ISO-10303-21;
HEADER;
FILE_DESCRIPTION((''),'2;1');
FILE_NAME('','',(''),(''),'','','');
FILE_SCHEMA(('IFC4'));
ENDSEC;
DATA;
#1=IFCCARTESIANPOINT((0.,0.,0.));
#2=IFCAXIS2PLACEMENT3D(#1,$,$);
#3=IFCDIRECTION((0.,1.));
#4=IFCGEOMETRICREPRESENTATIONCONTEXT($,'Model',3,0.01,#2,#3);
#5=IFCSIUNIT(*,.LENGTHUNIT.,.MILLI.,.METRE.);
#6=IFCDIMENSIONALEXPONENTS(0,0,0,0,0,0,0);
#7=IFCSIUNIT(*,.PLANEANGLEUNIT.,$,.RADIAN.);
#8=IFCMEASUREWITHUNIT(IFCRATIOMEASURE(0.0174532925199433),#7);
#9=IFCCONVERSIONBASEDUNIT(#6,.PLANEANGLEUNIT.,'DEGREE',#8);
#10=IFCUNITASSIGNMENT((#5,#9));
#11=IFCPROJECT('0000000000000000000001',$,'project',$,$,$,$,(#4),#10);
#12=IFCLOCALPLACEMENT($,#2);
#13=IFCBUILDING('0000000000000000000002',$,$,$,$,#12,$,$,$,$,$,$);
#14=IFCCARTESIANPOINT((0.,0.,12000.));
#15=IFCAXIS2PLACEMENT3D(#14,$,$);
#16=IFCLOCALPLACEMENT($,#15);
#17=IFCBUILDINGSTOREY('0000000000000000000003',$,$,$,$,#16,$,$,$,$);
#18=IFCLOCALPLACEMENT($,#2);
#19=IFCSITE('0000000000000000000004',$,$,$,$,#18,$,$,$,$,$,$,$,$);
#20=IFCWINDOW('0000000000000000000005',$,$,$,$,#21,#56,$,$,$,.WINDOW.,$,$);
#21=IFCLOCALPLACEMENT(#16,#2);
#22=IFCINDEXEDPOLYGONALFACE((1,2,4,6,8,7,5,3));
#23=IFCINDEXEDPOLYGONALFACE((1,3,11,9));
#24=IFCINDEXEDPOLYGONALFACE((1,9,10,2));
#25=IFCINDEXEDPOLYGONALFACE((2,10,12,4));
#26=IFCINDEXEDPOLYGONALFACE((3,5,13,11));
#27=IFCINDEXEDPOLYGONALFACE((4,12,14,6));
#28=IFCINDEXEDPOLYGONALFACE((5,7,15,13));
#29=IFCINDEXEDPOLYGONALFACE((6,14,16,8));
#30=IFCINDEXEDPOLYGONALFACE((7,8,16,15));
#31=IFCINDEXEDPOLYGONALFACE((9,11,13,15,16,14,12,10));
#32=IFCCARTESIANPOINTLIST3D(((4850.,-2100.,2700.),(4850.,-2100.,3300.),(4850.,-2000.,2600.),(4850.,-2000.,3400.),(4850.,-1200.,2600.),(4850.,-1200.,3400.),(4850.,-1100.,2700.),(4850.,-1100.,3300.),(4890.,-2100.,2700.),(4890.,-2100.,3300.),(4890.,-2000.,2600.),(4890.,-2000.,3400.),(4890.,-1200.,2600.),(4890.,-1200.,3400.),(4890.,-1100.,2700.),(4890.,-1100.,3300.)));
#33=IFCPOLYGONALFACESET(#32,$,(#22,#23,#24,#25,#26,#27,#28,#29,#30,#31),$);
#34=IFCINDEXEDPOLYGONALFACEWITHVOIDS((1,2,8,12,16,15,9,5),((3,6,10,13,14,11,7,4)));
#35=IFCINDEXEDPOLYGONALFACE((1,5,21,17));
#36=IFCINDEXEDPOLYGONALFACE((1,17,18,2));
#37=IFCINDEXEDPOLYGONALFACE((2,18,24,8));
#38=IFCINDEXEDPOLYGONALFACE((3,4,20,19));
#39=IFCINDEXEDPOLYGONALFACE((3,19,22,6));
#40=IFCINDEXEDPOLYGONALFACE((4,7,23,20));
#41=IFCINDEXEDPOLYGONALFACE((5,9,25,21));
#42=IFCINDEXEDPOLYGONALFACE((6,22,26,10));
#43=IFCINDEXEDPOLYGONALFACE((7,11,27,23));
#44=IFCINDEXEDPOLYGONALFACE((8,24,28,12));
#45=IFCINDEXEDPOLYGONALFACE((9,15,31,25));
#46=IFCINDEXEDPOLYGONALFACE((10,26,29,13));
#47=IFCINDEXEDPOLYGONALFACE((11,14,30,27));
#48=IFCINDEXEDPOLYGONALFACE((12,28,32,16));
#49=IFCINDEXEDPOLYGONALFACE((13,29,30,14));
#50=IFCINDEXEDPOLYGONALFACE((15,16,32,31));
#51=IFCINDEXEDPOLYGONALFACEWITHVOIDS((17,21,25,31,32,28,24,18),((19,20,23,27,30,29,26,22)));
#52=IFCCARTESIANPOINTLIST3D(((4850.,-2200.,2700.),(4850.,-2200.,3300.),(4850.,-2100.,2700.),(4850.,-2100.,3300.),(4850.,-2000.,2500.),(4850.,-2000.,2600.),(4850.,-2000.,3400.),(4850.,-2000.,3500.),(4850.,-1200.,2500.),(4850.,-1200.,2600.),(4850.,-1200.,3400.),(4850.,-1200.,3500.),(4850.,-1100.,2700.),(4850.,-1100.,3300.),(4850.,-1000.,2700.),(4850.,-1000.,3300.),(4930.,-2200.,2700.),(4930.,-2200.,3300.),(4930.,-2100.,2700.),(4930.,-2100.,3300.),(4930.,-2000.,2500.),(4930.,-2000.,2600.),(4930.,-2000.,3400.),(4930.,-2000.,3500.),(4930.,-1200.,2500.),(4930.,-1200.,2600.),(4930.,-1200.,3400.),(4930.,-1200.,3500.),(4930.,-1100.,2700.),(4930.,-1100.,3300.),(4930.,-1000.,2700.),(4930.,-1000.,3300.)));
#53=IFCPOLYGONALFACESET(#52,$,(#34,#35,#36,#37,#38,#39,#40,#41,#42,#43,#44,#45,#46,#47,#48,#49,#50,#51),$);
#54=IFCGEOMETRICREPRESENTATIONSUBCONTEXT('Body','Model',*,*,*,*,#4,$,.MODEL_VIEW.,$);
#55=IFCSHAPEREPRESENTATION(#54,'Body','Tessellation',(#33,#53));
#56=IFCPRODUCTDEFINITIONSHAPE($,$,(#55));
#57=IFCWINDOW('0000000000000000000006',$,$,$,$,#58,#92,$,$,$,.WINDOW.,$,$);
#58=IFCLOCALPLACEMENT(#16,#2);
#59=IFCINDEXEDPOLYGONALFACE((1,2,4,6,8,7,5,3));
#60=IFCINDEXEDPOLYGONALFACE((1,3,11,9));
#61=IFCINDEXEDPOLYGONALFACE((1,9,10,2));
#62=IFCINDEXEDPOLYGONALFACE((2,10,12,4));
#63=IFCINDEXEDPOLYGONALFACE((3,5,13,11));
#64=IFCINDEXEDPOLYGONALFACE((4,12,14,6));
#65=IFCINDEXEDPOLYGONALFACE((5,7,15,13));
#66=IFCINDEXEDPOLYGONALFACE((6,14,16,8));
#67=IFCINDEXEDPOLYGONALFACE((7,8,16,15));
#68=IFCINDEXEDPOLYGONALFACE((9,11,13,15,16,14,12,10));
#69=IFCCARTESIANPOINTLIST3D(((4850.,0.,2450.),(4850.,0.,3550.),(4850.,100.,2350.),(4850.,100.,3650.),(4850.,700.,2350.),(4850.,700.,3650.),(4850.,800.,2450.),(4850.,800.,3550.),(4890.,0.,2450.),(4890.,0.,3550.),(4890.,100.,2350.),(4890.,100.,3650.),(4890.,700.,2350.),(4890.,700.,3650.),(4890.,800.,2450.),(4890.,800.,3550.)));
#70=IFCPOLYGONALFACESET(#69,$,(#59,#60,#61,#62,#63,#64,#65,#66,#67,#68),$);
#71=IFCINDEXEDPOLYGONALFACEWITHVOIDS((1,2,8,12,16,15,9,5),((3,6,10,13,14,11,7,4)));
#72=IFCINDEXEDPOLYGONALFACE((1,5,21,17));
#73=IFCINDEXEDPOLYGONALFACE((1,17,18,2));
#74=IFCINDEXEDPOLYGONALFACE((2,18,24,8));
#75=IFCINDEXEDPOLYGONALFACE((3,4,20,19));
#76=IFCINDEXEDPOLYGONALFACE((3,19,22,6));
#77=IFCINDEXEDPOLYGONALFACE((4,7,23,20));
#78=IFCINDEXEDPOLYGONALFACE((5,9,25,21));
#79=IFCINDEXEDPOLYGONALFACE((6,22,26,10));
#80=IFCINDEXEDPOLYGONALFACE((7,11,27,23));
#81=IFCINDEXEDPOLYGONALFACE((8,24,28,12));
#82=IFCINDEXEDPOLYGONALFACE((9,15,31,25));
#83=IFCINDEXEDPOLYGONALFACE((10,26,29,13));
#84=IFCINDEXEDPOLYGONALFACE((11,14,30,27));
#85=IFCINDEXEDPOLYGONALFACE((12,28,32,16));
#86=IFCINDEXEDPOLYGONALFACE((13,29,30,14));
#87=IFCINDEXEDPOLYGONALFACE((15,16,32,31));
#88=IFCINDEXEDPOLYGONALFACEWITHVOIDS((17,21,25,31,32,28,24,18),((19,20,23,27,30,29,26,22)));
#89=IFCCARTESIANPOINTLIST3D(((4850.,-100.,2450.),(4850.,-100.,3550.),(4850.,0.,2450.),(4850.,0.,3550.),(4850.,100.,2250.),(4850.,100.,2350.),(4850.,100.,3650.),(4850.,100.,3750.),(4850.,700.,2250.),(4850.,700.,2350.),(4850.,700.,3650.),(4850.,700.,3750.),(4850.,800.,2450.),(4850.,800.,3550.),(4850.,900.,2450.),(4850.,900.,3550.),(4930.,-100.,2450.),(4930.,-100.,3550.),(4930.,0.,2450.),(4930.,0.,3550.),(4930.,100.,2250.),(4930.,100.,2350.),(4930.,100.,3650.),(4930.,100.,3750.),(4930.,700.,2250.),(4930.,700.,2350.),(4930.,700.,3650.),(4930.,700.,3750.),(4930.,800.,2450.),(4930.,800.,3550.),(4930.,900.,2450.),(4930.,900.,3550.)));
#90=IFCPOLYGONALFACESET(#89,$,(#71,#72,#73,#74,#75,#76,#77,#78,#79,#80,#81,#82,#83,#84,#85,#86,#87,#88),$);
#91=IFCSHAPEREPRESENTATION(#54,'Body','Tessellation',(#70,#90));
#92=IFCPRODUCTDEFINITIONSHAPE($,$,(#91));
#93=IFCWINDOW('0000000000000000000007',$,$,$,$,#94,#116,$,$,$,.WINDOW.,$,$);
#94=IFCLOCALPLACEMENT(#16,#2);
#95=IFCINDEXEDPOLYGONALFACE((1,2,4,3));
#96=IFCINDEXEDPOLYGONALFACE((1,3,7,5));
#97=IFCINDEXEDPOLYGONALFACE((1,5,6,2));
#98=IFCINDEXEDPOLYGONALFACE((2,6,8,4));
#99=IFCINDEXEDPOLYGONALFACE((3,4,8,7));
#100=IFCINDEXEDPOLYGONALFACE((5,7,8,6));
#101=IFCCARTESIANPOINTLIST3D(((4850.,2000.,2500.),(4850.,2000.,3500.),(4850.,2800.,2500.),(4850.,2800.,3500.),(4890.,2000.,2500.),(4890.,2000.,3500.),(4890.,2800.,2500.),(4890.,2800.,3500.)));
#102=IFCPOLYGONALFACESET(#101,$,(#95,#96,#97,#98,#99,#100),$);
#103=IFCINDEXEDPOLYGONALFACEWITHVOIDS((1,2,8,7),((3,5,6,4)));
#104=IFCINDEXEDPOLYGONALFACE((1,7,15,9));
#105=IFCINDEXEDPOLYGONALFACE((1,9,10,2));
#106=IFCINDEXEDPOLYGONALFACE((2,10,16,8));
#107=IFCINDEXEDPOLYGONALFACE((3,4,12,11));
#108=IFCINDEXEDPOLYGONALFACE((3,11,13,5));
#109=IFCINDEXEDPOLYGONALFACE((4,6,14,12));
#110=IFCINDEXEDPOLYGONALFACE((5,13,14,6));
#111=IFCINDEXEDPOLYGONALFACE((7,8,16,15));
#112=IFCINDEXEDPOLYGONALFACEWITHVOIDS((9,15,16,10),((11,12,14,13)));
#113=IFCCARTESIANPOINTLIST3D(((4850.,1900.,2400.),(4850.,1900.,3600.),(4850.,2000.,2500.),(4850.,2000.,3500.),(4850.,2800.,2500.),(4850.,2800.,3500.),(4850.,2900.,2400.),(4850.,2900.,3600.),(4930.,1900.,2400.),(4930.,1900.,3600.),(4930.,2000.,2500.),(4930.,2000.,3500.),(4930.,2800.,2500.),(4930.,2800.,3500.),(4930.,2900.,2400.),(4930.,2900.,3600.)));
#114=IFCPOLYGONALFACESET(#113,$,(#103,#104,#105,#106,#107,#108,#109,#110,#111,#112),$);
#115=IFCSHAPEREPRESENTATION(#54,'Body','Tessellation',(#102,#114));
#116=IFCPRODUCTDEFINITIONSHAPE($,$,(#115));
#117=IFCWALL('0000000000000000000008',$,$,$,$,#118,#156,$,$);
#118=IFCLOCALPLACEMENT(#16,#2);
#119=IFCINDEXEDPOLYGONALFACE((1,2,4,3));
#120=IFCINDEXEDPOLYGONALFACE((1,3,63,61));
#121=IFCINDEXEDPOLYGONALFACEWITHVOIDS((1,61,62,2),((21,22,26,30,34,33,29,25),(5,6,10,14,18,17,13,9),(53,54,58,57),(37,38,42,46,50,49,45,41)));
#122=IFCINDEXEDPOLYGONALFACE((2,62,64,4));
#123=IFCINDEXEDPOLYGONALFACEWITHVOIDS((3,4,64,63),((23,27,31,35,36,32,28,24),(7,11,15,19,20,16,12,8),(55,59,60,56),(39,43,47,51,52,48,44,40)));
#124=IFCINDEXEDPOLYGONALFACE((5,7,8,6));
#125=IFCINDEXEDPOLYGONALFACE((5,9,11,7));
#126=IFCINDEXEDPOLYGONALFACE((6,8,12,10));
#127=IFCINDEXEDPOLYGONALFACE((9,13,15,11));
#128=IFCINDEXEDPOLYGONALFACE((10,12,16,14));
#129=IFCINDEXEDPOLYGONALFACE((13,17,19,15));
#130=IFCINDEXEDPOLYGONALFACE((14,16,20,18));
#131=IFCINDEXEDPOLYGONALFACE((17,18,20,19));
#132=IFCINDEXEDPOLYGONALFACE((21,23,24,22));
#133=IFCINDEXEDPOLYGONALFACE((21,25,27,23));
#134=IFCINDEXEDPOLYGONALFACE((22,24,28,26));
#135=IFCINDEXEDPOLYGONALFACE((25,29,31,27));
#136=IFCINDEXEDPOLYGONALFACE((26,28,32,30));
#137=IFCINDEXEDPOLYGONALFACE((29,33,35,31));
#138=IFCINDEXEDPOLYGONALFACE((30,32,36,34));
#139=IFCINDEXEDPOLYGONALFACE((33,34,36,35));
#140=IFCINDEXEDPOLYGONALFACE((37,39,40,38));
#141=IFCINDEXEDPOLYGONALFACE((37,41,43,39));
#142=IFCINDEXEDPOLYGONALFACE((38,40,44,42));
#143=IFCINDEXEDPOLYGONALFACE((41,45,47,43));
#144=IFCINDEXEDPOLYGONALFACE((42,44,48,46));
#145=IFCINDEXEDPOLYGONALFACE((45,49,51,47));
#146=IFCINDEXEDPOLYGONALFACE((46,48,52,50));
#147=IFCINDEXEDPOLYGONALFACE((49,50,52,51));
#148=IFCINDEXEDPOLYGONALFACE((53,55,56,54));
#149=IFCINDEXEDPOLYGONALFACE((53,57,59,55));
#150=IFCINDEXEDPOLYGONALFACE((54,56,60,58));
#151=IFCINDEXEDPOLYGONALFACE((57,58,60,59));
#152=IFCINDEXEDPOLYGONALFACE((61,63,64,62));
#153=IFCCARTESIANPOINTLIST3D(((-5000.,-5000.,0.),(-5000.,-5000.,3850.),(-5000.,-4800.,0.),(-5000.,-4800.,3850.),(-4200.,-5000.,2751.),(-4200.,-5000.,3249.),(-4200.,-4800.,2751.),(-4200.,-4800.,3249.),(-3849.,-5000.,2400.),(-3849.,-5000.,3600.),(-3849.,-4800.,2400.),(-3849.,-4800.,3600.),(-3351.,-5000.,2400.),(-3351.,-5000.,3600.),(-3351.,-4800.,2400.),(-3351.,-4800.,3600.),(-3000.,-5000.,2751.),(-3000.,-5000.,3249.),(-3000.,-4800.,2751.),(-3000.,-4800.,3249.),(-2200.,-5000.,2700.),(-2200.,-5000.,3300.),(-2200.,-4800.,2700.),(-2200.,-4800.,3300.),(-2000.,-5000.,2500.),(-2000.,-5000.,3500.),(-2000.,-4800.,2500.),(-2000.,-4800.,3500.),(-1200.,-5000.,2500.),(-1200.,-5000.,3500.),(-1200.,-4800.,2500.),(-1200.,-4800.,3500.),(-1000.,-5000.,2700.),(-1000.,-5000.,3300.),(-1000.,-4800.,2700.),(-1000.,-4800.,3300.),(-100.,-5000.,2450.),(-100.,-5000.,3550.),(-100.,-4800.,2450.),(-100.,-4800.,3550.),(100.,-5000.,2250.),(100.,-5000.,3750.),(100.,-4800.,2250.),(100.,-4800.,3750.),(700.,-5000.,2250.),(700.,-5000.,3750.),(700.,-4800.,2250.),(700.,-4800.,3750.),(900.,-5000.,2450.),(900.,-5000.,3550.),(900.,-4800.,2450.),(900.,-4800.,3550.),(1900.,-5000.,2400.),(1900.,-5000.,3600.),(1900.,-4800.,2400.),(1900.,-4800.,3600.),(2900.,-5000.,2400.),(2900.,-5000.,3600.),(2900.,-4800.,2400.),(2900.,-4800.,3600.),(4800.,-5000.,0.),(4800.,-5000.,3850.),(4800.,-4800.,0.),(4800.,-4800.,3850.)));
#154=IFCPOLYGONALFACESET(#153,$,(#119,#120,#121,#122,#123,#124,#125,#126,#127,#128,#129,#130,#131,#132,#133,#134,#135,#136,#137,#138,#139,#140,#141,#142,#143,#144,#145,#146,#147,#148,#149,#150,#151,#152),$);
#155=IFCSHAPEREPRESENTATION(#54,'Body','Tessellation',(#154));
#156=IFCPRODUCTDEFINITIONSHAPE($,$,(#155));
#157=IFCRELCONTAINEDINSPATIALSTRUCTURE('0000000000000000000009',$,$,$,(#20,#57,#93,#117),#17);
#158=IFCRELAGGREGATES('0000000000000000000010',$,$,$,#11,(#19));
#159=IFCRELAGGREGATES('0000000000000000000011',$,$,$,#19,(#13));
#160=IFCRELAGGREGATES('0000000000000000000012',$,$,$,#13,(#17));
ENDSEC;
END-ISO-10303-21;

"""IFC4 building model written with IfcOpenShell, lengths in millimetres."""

from ifc_helpers import new_model, entity, si_unit, converted_unit, direction, frame, origin, origin_2d, place, context, subcontext, project, spatial, polyline, rectangle, outline, extrude, element, save


model = new_model("IFC4")

# Units and contexts
model_context = context("Model", 3, precision=0.01, world=origin(), true_north=direction((0.0, 1.0)))
body_context = subcontext(model_context, "Body", "Model", "MODEL_VIEW")
ifc_project = project(units=[si_unit("LENGTHUNIT", "METRE", prefix="MILLI"), converted_unit("PLANEANGLEUNIT", "DEGREE", entity("IfcRatioMeasure", 0.0174532925199433), si_unit("PLANEANGLEUNIT", "RADIAN"), dimensions=[0, 0, 0, 0, 0, 0, 0])], contexts=[model_context])

# Site, building, storey
site_placement = place(None, origin())
site = spatial("IfcSite", under=ifc_project, at=site_placement)
building_placement = place(None, origin())
building = spatial("IfcBuilding", under=site, at=building_placement)
storey_placement = place(None, frame((0.0, 0.0, 12000.0)))
storey = spatial("IfcBuildingStorey", under=building, at=storey_placement)

# Shared definitions
cartesian_point_1 = entity("IfcCartesianPoint", [-500.0, -300.0])
shared_polyline_1 = entity("IfcPolyline", [cartesian_point_1, entity("IfcCartesianPoint", [-500.0, 300.0]), entity("IfcCartesianPoint", [-400.0, 400.0]), entity("IfcCartesianPoint", [400.0, 400.0]), entity("IfcCartesianPoint", [500.0, 300.0]), entity("IfcCartesianPoint", [500.0, -300.0]), entity("IfcCartesianPoint", [400.0, -400.0]), entity("IfcCartesianPoint", [-400.0, -400.0]), cartesian_point_1])
cartesian_point_2 = entity("IfcCartesianPoint", [-400.0, -550.0])
shared_polyline_2 = entity("IfcPolyline", [cartesian_point_2, entity("IfcCartesianPoint", [-400.0, 550.0]), entity("IfcCartesianPoint", [-300.0, 650.0]), entity("IfcCartesianPoint", [300.0, 650.0]), entity("IfcCartesianPoint", [400.0, 550.0]), entity("IfcCartesianPoint", [400.0, -550.0]), entity("IfcCartesianPoint", [300.0, -650.0]), entity("IfcCartesianPoint", [-300.0, -650.0]), cartesian_point_2])
cartesian_point_3 = entity("IfcCartesianPoint", [-400.0, -500.0])
shared_polyline_3 = entity("IfcPolyline", [cartesian_point_3, entity("IfcCartesianPoint", [-400.0, 500.0]), entity("IfcCartesianPoint", [-400.0, 500.0]), entity("IfcCartesianPoint", [400.0, 500.0]), entity("IfcCartesianPoint", [400.0, 500.0]), entity("IfcCartesianPoint", [400.0, -500.0]), entity("IfcCartesianPoint", [400.0, -500.0]), entity("IfcCartesianPoint", [-400.0, -500.0]), cartesian_point_3])

# Shared definitions
wall_1_placement = place(storey_placement, frame((4900.0, -100.0, 0.0), z_axis=(0.0, 0.0, 1.0), x_axis=(0.0, 1.0, 0.0)))
window_1_placement = place(wall_1_placement, frame((-1500.0, 50.0, 3000.0)))
window_2_placement = place(wall_1_placement, frame((500.0, 50.0, 3000.0)))
window_3_placement = place(wall_1_placement, frame((2500.0, 50.0, 3000.0)))

# Windows
cartesian_point_4 = entity("IfcCartesianPoint", [-600.0, -300.0])
element("IfcWindow", 1, at=window_1_placement, inside=storey, PredefinedType="WINDOW", context=body_context, shape_type="SweptSolid", body=[
    entity("IfcExtrudedAreaSolid", entity("IfcArbitraryClosedProfileDef", "AREA", None, shared_polyline_1), entity("IfcAxis2Placement3D", entity("IfcCartesianPoint", [0.0, 0.0, 0.0]), entity("IfcDirection", [0.0, -1.0, 0.0]), entity("IfcDirection", [1.0, 0.0, 0.0])), entity("IfcDirection", [0.0, 0.0, 1.0]), 40.0),
    entity("IfcExtrudedAreaSolid", entity("IfcArbitraryProfileDefWithVoids", "AREA", None, entity("IfcPolyline", [cartesian_point_4, entity("IfcCartesianPoint", [-600.0, 300.0]), entity("IfcCartesianPoint", [-400.0, 500.0]), entity("IfcCartesianPoint", [400.0, 500.0]), entity("IfcCartesianPoint", [600.0, 300.0]), entity("IfcCartesianPoint", [600.0, -300.0]), entity("IfcCartesianPoint", [400.0, -500.0]), entity("IfcCartesianPoint", [-400.0, -500.0]), cartesian_point_4]), [shared_polyline_1]), entity("IfcAxis2Placement3D", entity("IfcCartesianPoint", [0.0, 0.0, 0.0]), entity("IfcDirection", [0.0, -1.0, 0.0]), entity("IfcDirection", [1.0, 0.0, 0.0])), entity("IfcDirection", [0.0, 0.0, 1.0]), 80.0),
])
cartesian_point_5 = entity("IfcCartesianPoint", [-500.0, -550.0])
element("IfcWindow", 2, at=window_2_placement, inside=storey, PredefinedType="WINDOW", context=body_context, shape_type="SweptSolid", body=[
    entity("IfcExtrudedAreaSolid", entity("IfcArbitraryClosedProfileDef", "AREA", None, shared_polyline_2), entity("IfcAxis2Placement3D", entity("IfcCartesianPoint", [0.0, 0.0, 0.0]), entity("IfcDirection", [0.0, -1.0, 0.0]), entity("IfcDirection", [1.0, 0.0, 0.0])), entity("IfcDirection", [0.0, 0.0, 1.0]), 40.0),
    entity("IfcExtrudedAreaSolid", entity("IfcArbitraryProfileDefWithVoids", "AREA", None, entity("IfcPolyline", [cartesian_point_5, entity("IfcCartesianPoint", [-500.0, 550.0]), entity("IfcCartesianPoint", [-300.0, 750.0]), entity("IfcCartesianPoint", [300.0, 750.0]), entity("IfcCartesianPoint", [500.0, 550.0]), entity("IfcCartesianPoint", [500.0, -550.0]), entity("IfcCartesianPoint", [300.0, -750.0]), entity("IfcCartesianPoint", [-300.0, -750.0]), cartesian_point_5]), [shared_polyline_2]), entity("IfcAxis2Placement3D", entity("IfcCartesianPoint", [0.0, 0.0, 0.0]), entity("IfcDirection", [0.0, -1.0, 0.0]), entity("IfcDirection", [1.0, 0.0, 0.0])), entity("IfcDirection", [0.0, 0.0, 1.0]), 80.0),
])
cartesian_point_6 = entity("IfcCartesianPoint", [-500.0, -600.0])
element("IfcWindow", 3, at=window_3_placement, inside=storey, PredefinedType="WINDOW", context=body_context, shape_type="SweptSolid", body=[
    entity("IfcExtrudedAreaSolid", entity("IfcArbitraryClosedProfileDef", "AREA", None, shared_polyline_3), entity("IfcAxis2Placement3D", entity("IfcCartesianPoint", [0.0, 0.0, 0.0]), entity("IfcDirection", [0.0, -1.0, 0.0]), entity("IfcDirection", [1.0, 0.0, 0.0])), entity("IfcDirection", [0.0, 0.0, 1.0]), 40.0),
    entity("IfcExtrudedAreaSolid", entity("IfcArbitraryProfileDefWithVoids", "AREA", None, entity("IfcPolyline", [cartesian_point_6, entity("IfcCartesianPoint", [-500.0, 600.0]), entity("IfcCartesianPoint", [-500.0, 600.0]), entity("IfcCartesianPoint", [500.0, 600.0]), entity("IfcCartesianPoint", [500.0, 600.0]), entity("IfcCartesianPoint", [500.0, -600.0]), entity("IfcCartesianPoint", [500.0, -600.0]), entity("IfcCartesianPoint", [-500.0, -600.0]), cartesian_point_6]), [shared_polyline_3]), entity("IfcAxis2Placement3D", entity("IfcCartesianPoint", [0.0, 0.0, 0.0]), entity("IfcDirection", [0.0, -1.0, 0.0]), entity("IfcDirection", [1.0, 0.0, 0.0])), entity("IfcDirection", [0.0, 0.0, 1.0]), 80.0),
])

# Wall, openings
wall_2_placement = place(storey_placement, frame((-100.0, -4900.0, 0.0), z_axis=(0.0, 0.0, 1.0), x_axis=(1.0, 0.0, 0.0)))
wall_2 = element("IfcWall", 4, at=wall_2_placement, inside=storey, context=body_context, shape_type="SweptSolid", body=[
    extrude(rectangle(XDim=9800.0, YDim=200.0, at=origin_2d()), origin(), (0.0, 0.0, 1.0), 3850.0),
])
window_4_placement = place(wall_2_placement, frame((-3500.0, 50.0, 3000.0)))
opening_1_placement = place(window_4_placement, frame((0.0, 50.0, 0.0)))
element("IfcOpeningElement", 5, at=opening_1_placement, cuts=wall_2, context=body_context, shape_type="SweptSolid", body=[
    extrude(outline(polyline([(-600.0, -249.0), (-600.0, 249.0), (-249.0, 600.0), (249.0, 600.0), (600.0, 249.0), (600.0, -249.0), (249.0, -600.0), (-249.0, -600.0), (-600.0, -249.0)])), frame((0.0, 0.0, 0.0), z_axis=(0.0, -1.0, 0.0), x_axis=(1.0, 0.0, 0.0)), (0.0, 0.0, 1.0), 200.0),
])
window_5_placement = place(wall_2_placement, frame((-1500.0, 50.0, 3000.0)))
opening_2_placement = place(window_5_placement, frame((0.0, 50.0, 0.0)))
element("IfcOpeningElement", 6, at=opening_2_placement, cuts=wall_2, context=body_context, shape_type="SweptSolid", body=[
    extrude(outline(polyline([(-600.0, -300.0), (-600.0, 300.0), (-400.0, 500.0), (400.0, 500.0), (600.0, 300.0), (600.0, -300.0), (400.0, -500.0), (-400.0, -500.0), (-600.0, -300.0)])), frame((0.0, 0.0, 0.0), z_axis=(0.0, -1.0, 0.0), x_axis=(1.0, 0.0, 0.0)), (0.0, 0.0, 1.0), 200.0),
])
window_6_placement = place(wall_2_placement, frame((500.0, 50.0, 3000.0)))
opening_3_placement = place(window_6_placement, frame((0.0, 50.0, 0.0)))
element("IfcOpeningElement", 7, at=opening_3_placement, cuts=wall_2, context=body_context, shape_type="SweptSolid", body=[
    extrude(outline(polyline([(-500.0, -550.0), (-500.0, 550.0), (-300.0, 750.0), (300.0, 750.0), (500.0, 550.0), (500.0, -550.0), (300.0, -750.0), (-300.0, -750.0), (-500.0, -550.0)])), frame((0.0, 0.0, 0.0), z_axis=(0.0, -1.0, 0.0), x_axis=(1.0, 0.0, 0.0)), (0.0, 0.0, 1.0), 200.0),
])
window_7_placement = place(wall_2_placement, frame((2500.0, 50.0, 3000.0)))
opening_4_placement = place(window_7_placement, frame((0.0, 50.0, 0.0)))
element("IfcOpeningElement", 8, at=opening_4_placement, cuts=wall_2, context=body_context, shape_type="SweptSolid", body=[
    extrude(outline(polyline([(-500.0, -600.0), (-500.0, 600.0), (-500.0, 600.0), (500.0, 600.0), (500.0, 600.0), (500.0, -600.0), (500.0, -600.0), (-500.0, -600.0), (-500.0, -600.0)])), frame((0.0, 0.0, 0.0), z_axis=(0.0, -1.0, 0.0), x_axis=(1.0, 0.0, 0.0)), (0.0, 0.0, 1.0), 200.0),
])

save(model, "model.ifc")
